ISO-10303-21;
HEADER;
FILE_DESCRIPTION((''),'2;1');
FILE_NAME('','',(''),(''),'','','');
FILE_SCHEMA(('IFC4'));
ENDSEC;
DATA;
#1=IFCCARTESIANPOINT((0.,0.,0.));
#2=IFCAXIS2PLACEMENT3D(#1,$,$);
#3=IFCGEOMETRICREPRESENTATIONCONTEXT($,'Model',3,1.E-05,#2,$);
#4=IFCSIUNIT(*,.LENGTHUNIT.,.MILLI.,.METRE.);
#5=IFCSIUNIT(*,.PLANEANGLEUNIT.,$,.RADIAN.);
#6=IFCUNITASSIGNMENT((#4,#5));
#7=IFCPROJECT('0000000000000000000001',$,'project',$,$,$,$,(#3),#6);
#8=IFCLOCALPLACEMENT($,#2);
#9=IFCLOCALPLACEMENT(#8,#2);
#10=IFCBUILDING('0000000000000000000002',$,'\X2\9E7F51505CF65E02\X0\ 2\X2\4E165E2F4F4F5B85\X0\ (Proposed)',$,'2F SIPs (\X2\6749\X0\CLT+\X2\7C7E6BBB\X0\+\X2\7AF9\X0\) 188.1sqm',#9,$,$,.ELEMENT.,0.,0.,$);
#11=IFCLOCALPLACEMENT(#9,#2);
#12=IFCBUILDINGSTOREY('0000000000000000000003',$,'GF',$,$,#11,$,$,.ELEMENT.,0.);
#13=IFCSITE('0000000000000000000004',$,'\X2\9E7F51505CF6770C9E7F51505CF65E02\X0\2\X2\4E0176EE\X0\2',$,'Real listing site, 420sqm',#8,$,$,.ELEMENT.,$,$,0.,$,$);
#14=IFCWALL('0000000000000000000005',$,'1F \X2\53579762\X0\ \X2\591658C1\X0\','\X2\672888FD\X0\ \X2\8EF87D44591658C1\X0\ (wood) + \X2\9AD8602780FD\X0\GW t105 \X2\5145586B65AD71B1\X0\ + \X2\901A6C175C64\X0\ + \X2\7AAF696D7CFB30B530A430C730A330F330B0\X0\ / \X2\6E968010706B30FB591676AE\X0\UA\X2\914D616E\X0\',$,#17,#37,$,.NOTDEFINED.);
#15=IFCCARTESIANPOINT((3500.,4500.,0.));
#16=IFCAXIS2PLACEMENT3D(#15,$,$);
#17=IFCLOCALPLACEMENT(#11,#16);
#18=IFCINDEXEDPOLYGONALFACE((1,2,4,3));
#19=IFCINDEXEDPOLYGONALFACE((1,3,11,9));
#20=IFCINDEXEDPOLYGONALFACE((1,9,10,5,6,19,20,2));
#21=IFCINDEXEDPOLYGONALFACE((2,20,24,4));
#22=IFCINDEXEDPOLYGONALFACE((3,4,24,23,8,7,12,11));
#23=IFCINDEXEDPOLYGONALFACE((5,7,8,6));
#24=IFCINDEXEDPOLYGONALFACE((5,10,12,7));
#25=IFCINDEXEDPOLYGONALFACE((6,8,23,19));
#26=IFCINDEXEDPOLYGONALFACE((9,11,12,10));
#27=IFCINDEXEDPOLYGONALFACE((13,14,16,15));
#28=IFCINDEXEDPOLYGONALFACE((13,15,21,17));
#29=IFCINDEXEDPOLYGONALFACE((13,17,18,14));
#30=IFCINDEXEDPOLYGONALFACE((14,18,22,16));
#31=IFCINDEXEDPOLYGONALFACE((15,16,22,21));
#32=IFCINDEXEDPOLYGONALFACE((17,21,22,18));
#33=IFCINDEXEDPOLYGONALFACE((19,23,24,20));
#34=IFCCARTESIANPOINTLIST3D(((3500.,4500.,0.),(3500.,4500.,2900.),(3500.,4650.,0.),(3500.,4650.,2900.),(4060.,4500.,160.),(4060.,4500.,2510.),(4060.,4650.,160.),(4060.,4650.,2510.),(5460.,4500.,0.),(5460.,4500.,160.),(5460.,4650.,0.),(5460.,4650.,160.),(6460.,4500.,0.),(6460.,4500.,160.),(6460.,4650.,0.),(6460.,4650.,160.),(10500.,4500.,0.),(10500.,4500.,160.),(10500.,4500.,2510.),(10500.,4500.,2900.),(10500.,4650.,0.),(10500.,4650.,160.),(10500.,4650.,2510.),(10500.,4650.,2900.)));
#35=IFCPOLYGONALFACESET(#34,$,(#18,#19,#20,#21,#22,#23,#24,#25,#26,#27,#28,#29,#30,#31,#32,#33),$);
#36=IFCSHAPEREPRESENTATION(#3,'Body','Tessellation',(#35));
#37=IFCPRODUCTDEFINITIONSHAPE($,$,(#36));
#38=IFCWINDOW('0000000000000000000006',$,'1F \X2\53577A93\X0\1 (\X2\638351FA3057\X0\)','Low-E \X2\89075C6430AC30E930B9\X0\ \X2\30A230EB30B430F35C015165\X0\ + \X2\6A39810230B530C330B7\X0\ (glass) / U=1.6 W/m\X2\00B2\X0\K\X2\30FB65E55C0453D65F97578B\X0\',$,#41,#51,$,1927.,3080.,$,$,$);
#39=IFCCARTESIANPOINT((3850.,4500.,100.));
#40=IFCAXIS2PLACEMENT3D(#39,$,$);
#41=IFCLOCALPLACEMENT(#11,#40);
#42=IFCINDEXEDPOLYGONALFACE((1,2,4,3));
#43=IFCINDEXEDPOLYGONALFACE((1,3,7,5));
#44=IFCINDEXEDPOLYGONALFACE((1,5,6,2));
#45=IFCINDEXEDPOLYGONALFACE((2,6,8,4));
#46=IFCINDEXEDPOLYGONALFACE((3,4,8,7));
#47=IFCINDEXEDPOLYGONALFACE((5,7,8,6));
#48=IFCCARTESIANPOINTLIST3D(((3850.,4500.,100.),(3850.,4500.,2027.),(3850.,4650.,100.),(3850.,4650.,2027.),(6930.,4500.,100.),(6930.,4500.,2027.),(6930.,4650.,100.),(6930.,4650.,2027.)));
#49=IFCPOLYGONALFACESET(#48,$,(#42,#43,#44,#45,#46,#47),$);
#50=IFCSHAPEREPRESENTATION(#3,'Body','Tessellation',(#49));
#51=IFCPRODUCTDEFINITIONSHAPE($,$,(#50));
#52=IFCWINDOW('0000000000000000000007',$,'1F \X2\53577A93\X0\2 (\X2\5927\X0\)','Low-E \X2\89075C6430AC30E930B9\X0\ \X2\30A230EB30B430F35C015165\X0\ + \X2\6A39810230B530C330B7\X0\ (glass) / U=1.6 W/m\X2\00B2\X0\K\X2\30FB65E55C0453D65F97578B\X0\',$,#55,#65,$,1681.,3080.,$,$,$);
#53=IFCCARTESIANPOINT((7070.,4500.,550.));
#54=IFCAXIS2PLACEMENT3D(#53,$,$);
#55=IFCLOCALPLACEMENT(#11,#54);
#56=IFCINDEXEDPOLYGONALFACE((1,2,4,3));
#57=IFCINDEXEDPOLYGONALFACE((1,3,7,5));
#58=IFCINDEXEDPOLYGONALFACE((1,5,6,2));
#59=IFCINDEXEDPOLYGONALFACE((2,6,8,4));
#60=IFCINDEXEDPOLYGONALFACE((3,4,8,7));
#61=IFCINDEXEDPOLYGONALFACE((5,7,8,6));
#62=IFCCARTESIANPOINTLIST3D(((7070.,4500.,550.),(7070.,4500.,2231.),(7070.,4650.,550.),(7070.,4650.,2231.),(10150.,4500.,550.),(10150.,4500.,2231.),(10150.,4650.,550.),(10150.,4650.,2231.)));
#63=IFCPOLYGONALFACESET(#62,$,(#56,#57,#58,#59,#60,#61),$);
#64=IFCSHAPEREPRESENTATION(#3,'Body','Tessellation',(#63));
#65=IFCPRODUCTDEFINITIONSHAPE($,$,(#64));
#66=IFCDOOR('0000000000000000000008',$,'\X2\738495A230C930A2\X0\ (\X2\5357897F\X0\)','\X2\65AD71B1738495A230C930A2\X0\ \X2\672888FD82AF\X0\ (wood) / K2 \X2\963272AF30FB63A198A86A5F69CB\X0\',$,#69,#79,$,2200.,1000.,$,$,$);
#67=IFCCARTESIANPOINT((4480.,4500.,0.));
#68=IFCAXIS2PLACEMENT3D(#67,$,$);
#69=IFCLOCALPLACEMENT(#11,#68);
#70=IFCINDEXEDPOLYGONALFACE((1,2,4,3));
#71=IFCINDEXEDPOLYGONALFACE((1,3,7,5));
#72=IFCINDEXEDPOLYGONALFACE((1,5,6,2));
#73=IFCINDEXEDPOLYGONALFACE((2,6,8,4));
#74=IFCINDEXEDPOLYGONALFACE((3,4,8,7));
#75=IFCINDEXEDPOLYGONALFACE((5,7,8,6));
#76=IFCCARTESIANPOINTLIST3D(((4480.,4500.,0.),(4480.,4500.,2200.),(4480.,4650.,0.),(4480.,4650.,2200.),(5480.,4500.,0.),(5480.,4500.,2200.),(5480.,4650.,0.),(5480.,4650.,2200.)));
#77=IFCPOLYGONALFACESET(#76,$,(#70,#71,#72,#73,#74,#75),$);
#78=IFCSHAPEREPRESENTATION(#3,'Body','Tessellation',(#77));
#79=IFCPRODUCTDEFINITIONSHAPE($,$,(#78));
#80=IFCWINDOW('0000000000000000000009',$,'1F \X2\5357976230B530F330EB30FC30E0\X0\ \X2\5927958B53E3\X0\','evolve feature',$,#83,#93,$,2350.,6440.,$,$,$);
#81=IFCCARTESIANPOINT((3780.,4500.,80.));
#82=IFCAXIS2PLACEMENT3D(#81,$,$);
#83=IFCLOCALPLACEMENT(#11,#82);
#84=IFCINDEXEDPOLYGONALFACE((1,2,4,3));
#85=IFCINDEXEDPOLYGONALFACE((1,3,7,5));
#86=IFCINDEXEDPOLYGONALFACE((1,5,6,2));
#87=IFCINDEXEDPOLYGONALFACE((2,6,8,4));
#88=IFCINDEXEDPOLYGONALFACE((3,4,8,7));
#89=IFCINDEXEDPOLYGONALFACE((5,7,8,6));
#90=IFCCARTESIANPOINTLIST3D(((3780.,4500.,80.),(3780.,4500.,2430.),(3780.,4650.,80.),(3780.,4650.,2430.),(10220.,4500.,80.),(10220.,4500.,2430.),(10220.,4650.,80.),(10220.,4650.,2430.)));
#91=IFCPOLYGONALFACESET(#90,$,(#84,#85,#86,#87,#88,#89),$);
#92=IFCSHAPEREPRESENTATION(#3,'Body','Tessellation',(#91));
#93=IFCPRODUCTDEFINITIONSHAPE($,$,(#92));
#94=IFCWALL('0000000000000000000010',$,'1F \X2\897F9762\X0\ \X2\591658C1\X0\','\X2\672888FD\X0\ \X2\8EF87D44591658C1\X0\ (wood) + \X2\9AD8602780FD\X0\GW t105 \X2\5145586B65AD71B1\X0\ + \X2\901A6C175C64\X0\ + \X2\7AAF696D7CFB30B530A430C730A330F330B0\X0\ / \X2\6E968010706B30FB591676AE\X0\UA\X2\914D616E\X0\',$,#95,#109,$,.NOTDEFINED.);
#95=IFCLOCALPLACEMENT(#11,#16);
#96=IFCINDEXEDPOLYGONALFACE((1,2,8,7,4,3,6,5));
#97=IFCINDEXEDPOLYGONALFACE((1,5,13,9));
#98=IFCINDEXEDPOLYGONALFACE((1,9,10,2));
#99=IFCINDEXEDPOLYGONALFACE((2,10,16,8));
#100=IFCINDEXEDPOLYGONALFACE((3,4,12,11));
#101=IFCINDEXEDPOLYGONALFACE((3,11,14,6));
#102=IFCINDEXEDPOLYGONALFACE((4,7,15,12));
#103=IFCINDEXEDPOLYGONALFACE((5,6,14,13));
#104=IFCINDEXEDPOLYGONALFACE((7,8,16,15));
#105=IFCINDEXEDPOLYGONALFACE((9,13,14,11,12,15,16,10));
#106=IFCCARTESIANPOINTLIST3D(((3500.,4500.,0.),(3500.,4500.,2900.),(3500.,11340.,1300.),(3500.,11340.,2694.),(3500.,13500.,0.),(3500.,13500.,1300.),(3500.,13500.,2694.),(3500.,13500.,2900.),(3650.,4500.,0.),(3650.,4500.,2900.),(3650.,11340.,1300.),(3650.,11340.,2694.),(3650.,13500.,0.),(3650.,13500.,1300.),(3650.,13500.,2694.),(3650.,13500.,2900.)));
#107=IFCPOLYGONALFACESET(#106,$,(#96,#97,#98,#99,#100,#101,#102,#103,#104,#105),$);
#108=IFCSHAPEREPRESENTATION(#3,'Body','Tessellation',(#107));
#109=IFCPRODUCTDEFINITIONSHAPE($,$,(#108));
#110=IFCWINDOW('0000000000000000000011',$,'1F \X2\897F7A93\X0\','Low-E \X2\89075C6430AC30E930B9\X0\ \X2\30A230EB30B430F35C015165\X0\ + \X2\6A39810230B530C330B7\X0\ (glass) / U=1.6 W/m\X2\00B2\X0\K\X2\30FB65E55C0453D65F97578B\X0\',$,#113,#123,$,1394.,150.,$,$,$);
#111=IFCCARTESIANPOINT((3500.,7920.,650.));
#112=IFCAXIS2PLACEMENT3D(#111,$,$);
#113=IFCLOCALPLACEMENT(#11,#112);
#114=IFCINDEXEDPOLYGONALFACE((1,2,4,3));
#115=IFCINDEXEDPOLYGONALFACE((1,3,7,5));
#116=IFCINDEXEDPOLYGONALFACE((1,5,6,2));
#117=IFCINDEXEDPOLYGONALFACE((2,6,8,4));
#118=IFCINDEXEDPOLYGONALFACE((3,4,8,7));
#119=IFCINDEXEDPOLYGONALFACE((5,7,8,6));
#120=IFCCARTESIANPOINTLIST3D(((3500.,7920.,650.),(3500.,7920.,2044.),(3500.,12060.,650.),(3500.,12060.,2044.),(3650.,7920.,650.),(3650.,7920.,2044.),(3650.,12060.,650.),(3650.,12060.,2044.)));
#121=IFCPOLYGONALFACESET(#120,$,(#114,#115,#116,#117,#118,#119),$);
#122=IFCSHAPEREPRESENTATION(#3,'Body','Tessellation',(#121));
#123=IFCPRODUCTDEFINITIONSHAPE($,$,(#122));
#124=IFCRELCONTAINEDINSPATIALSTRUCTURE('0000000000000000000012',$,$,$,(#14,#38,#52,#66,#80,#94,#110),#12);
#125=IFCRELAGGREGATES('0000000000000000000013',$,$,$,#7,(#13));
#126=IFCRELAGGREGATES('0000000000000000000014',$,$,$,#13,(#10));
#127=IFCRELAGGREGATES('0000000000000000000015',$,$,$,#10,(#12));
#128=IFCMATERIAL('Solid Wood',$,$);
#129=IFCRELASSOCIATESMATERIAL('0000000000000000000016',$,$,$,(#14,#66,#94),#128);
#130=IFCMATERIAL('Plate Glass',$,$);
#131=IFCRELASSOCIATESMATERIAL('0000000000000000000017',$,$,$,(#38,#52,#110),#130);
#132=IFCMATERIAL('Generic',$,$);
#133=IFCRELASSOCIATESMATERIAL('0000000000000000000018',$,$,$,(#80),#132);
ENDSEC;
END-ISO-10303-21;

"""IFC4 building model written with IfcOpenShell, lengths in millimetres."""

from ifc_helpers import new_model, si_unit, frame, frame_2d, origin, place, context, project, spatial, rectangle, extrude, material, element, fill, save


model = new_model("IFC4")

# Units and contexts
model_context = context("Model", 3, precision=1e-05, world=origin())
ifc_project = project(units=[si_unit("LENGTHUNIT", "METRE", prefix="MILLI"), si_unit("PLANEANGLEUNIT", "RADIAN")], contexts=[model_context])

# Site, building, storey
site_placement = place(None, origin())
site = spatial("IfcSite", under=ifc_project, at=site_placement, Name="鹿児島県鹿児島市2丁目2", ObjectType="Real listing site, 420sqm", CompositionType="ELEMENT", RefElevation=0.0)
building_placement = place(site_placement, origin())
building = spatial("IfcBuilding", under=site, at=building_placement, Name="鹿児島市 2世帯住宅 (Proposed)", ObjectType="2F SIPs (杉CLT+籾殻+竹) 188.1sqm", CompositionType="ELEMENT", ElevationOfRefHeight=0.0, ElevationOfTerrain=0.0)
storey_placement = place(building_placement, origin())
storey = spatial("IfcBuildingStorey", under=building, at=storey_placement, Name="GF", CompositionType="ELEMENT", Elevation=0.0)

# Shared definitions
ifc_material_1 = material(Name="Solid Wood")
ifc_material_2 = material(Name="Generic")

# Wall, openings, windows, door
wall_1_placement = place(storey_placement, frame((3500.0, 4500.0, 0.0)))
wall_1 = element("IfcWall", 1, at=wall_1_placement, inside=storey, material=ifc_material_1, Name="1F 南面 外壁", Description="木製 軸組外壁 (wood) + 高性能GW t105 充填断熱 + 通気層 + 窯業系サイディング / 準耐火・外皮UA配慮", PredefinedType="NOTDEFINED", context=model_context, shape_type="SweptSolid", body=[
    extrude(rectangle(XDim=7000.0, YDim=150.0, at=frame_2d((3500.0, 75.0))), frame((3500.0, 4500.0, 0.0)), (0.0, 0.0, 1.0), 2900.0),
])
opening_1_placement = place(storey_placement, frame((3850.0, 4500.0, 100.0)))
opening_1 = element("IfcOpeningElement", 2, at=opening_1_placement, cuts=wall_1, PredefinedType="NOTDEFINED", context=model_context, shape_type="SweptSolid", body=[
    extrude(rectangle(XDim=3080.0, YDim=150.0, at=frame_2d((1540.0, 75.0))), frame((3850.0, 4500.0, 100.0)), (0.0, 0.0, 1.0), 1927.0),
])
opening_2_placement = place(storey_placement, frame((7070.0, 4500.0, 550.0)))
opening_2 = element("IfcOpeningElement", 3, at=opening_2_placement, cuts=wall_1, PredefinedType="NOTDEFINED", context=model_context, shape_type="SweptSolid", body=[
    extrude(rectangle(XDim=3080.0, YDim=150.0, at=frame_2d((1540.0, 75.0))), frame((7070.0, 4500.0, 550.0)), (0.0, 0.0, 1.0), 1681.0),
])
opening_3_placement = place(storey_placement, frame((4480.0, 4500.0, 0.0)))
opening_3 = element("IfcOpeningElement", 4, at=opening_3_placement, cuts=wall_1, PredefinedType="NOTDEFINED", context=model_context, shape_type="SweptSolid", body=[
    extrude(rectangle(XDim=1000.0, YDim=150.0, at=frame_2d((500.0, 75.0))), frame((4480.0, 4500.0, 0.0)), (0.0, 0.0, 1.0), 2200.0),
])
opening_4_placement = place(storey_placement, frame((3780.0, 4500.0, 80.0)))
opening_4 = element("IfcOpeningElement", 5, at=opening_4_placement, cuts=wall_1, PredefinedType="NOTDEFINED", context=model_context, shape_type="SweptSolid", body=[
    extrude(rectangle(XDim=6440.0, YDim=150.0, at=frame_2d((3220.0, 75.0))), frame((3780.0, 4500.0, 80.0)), (0.0, 0.0, 1.0), 2350.0),
])
ifc_material_3 = material(Name="Plate Glass")
window_1_placement = place(storey_placement, frame((3850.0, 4500.0, 100.0)))
window_1 = element("IfcWindow", 6, at=window_1_placement, inside=storey, material=ifc_material_3, Name="1F 南窓1 (掃出し)", Description="Low-E 複層ガラス アルゴン封入 + 樹脂サッシ (glass) / U=1.6 W/m²K・日射取得型", OverallHeight=1927.0, OverallWidth=3080.0, context=model_context, shape_type="SweptSolid", body=[
    extrude(rectangle(XDim=3080.0, YDim=150.0, at=frame_2d((1540.0, 75.0))), frame((3850.0, 4500.0, 100.0)), (0.0, 0.0, 1.0), 1927.0),
])
fill(opening_1, window_1)
window_2_placement = place(storey_placement, frame((7070.0, 4500.0, 550.0)))
window_2 = element("IfcWindow", 7, at=window_2_placement, inside=storey, material=ifc_material_3, Name="1F 南窓2 (大)", Description="Low-E 複層ガラス アルゴン封入 + 樹脂サッシ (glass) / U=1.6 W/m²K・日射取得型", OverallHeight=1681.0, OverallWidth=3080.0, context=model_context, shape_type="SweptSolid", body=[
    extrude(rectangle(XDim=3080.0, YDim=150.0, at=frame_2d((1540.0, 75.0))), frame((7070.0, 4500.0, 550.0)), (0.0, 0.0, 1.0), 1681.0),
])
fill(opening_2, window_2)
door_placement = place(storey_placement, frame((4480.0, 4500.0, 0.0)))
door = element("IfcDoor", 8, at=door_placement, inside=storey, material=ifc_material_1, Name="玄関ドア (南西)", Description="断熱玄関ドア 木製芯 (wood) / K2 防犯・採風機構", OverallHeight=2200.0, OverallWidth=1000.0, context=model_context, shape_type="SweptSolid", body=[
    extrude(rectangle(XDim=1000.0, YDim=150.0, at=frame_2d((500.0, 75.0))), frame((4480.0, 4500.0, 0.0)), (0.0, 0.0, 1.0), 2200.0),
])
fill(opening_3, door)
window_3_placement = place(storey_placement, frame((3780.0, 4500.0, 80.0)))
window_3 = element("IfcWindow", 9, at=window_3_placement, inside=storey, material=ifc_material_2, Name="1F 南面サンルーム 大開口", Description="evolve feature", OverallHeight=2350.0, OverallWidth=6440.0, context=model_context, shape_type="SweptSolid", body=[
    extrude(rectangle(XDim=6440.0, YDim=150.0, at=frame_2d((3220.0, 75.0))), frame((3780.0, 4500.0, 80.0)), (0.0, 0.0, 1.0), 2350.0),
])
fill(opening_4, window_3)

# Wall, opening, window
wall_2_placement = place(storey_placement, frame((3500.0, 4500.0, 0.0)))
wall_2 = element("IfcWall", 10, at=wall_2_placement, inside=storey, material=ifc_material_1, Name="1F 西面 外壁", Description="木製 軸組外壁 (wood) + 高性能GW t105 充填断熱 + 通気層 + 窯業系サイディング / 準耐火・外皮UA配慮", PredefinedType="NOTDEFINED", context=model_context, shape_type="SweptSolid", body=[
    extrude(rectangle(XDim=150.0, YDim=9000.0, at=frame_2d((75.0, 4500.0))), frame((3500.0, 4500.0, 0.0)), (0.0, 0.0, 1.0), 2900.0),
])
opening_5_placement = place(storey_placement, frame((3500.0, 7920.0, 650.0)))
opening_5 = element("IfcOpeningElement", 11, at=opening_5_placement, cuts=wall_2, PredefinedType="NOTDEFINED", context=model_context, shape_type="SweptSolid", body=[
    extrude(rectangle(XDim=150.0, YDim=4140.0, at=frame_2d((75.0, 2070.0))), frame((3500.0, 7920.0, 650.0)), (0.0, 0.0, 1.0), 1394.0),
])
window_4_placement = place(storey_placement, frame((3500.0, 7920.0, 650.0)))
window_4 = element("IfcWindow", 12, at=window_4_placement, inside=storey, material=ifc_material_3, Name="1F 西窓", Description="Low-E 複層ガラス アルゴン封入 + 樹脂サッシ (glass) / U=1.6 W/m²K・日射取得型", OverallHeight=1394.0, OverallWidth=150.0, context=model_context, shape_type="SweptSolid", body=[
    extrude(rectangle(XDim=150.0, YDim=4140.0, at=frame_2d((75.0, 2070.0))), frame((3500.0, 7920.0, 650.0)), (0.0, 0.0, 1.0), 1394.0),
])
fill(opening_5, window_4)

save(model, "model.ifc")
